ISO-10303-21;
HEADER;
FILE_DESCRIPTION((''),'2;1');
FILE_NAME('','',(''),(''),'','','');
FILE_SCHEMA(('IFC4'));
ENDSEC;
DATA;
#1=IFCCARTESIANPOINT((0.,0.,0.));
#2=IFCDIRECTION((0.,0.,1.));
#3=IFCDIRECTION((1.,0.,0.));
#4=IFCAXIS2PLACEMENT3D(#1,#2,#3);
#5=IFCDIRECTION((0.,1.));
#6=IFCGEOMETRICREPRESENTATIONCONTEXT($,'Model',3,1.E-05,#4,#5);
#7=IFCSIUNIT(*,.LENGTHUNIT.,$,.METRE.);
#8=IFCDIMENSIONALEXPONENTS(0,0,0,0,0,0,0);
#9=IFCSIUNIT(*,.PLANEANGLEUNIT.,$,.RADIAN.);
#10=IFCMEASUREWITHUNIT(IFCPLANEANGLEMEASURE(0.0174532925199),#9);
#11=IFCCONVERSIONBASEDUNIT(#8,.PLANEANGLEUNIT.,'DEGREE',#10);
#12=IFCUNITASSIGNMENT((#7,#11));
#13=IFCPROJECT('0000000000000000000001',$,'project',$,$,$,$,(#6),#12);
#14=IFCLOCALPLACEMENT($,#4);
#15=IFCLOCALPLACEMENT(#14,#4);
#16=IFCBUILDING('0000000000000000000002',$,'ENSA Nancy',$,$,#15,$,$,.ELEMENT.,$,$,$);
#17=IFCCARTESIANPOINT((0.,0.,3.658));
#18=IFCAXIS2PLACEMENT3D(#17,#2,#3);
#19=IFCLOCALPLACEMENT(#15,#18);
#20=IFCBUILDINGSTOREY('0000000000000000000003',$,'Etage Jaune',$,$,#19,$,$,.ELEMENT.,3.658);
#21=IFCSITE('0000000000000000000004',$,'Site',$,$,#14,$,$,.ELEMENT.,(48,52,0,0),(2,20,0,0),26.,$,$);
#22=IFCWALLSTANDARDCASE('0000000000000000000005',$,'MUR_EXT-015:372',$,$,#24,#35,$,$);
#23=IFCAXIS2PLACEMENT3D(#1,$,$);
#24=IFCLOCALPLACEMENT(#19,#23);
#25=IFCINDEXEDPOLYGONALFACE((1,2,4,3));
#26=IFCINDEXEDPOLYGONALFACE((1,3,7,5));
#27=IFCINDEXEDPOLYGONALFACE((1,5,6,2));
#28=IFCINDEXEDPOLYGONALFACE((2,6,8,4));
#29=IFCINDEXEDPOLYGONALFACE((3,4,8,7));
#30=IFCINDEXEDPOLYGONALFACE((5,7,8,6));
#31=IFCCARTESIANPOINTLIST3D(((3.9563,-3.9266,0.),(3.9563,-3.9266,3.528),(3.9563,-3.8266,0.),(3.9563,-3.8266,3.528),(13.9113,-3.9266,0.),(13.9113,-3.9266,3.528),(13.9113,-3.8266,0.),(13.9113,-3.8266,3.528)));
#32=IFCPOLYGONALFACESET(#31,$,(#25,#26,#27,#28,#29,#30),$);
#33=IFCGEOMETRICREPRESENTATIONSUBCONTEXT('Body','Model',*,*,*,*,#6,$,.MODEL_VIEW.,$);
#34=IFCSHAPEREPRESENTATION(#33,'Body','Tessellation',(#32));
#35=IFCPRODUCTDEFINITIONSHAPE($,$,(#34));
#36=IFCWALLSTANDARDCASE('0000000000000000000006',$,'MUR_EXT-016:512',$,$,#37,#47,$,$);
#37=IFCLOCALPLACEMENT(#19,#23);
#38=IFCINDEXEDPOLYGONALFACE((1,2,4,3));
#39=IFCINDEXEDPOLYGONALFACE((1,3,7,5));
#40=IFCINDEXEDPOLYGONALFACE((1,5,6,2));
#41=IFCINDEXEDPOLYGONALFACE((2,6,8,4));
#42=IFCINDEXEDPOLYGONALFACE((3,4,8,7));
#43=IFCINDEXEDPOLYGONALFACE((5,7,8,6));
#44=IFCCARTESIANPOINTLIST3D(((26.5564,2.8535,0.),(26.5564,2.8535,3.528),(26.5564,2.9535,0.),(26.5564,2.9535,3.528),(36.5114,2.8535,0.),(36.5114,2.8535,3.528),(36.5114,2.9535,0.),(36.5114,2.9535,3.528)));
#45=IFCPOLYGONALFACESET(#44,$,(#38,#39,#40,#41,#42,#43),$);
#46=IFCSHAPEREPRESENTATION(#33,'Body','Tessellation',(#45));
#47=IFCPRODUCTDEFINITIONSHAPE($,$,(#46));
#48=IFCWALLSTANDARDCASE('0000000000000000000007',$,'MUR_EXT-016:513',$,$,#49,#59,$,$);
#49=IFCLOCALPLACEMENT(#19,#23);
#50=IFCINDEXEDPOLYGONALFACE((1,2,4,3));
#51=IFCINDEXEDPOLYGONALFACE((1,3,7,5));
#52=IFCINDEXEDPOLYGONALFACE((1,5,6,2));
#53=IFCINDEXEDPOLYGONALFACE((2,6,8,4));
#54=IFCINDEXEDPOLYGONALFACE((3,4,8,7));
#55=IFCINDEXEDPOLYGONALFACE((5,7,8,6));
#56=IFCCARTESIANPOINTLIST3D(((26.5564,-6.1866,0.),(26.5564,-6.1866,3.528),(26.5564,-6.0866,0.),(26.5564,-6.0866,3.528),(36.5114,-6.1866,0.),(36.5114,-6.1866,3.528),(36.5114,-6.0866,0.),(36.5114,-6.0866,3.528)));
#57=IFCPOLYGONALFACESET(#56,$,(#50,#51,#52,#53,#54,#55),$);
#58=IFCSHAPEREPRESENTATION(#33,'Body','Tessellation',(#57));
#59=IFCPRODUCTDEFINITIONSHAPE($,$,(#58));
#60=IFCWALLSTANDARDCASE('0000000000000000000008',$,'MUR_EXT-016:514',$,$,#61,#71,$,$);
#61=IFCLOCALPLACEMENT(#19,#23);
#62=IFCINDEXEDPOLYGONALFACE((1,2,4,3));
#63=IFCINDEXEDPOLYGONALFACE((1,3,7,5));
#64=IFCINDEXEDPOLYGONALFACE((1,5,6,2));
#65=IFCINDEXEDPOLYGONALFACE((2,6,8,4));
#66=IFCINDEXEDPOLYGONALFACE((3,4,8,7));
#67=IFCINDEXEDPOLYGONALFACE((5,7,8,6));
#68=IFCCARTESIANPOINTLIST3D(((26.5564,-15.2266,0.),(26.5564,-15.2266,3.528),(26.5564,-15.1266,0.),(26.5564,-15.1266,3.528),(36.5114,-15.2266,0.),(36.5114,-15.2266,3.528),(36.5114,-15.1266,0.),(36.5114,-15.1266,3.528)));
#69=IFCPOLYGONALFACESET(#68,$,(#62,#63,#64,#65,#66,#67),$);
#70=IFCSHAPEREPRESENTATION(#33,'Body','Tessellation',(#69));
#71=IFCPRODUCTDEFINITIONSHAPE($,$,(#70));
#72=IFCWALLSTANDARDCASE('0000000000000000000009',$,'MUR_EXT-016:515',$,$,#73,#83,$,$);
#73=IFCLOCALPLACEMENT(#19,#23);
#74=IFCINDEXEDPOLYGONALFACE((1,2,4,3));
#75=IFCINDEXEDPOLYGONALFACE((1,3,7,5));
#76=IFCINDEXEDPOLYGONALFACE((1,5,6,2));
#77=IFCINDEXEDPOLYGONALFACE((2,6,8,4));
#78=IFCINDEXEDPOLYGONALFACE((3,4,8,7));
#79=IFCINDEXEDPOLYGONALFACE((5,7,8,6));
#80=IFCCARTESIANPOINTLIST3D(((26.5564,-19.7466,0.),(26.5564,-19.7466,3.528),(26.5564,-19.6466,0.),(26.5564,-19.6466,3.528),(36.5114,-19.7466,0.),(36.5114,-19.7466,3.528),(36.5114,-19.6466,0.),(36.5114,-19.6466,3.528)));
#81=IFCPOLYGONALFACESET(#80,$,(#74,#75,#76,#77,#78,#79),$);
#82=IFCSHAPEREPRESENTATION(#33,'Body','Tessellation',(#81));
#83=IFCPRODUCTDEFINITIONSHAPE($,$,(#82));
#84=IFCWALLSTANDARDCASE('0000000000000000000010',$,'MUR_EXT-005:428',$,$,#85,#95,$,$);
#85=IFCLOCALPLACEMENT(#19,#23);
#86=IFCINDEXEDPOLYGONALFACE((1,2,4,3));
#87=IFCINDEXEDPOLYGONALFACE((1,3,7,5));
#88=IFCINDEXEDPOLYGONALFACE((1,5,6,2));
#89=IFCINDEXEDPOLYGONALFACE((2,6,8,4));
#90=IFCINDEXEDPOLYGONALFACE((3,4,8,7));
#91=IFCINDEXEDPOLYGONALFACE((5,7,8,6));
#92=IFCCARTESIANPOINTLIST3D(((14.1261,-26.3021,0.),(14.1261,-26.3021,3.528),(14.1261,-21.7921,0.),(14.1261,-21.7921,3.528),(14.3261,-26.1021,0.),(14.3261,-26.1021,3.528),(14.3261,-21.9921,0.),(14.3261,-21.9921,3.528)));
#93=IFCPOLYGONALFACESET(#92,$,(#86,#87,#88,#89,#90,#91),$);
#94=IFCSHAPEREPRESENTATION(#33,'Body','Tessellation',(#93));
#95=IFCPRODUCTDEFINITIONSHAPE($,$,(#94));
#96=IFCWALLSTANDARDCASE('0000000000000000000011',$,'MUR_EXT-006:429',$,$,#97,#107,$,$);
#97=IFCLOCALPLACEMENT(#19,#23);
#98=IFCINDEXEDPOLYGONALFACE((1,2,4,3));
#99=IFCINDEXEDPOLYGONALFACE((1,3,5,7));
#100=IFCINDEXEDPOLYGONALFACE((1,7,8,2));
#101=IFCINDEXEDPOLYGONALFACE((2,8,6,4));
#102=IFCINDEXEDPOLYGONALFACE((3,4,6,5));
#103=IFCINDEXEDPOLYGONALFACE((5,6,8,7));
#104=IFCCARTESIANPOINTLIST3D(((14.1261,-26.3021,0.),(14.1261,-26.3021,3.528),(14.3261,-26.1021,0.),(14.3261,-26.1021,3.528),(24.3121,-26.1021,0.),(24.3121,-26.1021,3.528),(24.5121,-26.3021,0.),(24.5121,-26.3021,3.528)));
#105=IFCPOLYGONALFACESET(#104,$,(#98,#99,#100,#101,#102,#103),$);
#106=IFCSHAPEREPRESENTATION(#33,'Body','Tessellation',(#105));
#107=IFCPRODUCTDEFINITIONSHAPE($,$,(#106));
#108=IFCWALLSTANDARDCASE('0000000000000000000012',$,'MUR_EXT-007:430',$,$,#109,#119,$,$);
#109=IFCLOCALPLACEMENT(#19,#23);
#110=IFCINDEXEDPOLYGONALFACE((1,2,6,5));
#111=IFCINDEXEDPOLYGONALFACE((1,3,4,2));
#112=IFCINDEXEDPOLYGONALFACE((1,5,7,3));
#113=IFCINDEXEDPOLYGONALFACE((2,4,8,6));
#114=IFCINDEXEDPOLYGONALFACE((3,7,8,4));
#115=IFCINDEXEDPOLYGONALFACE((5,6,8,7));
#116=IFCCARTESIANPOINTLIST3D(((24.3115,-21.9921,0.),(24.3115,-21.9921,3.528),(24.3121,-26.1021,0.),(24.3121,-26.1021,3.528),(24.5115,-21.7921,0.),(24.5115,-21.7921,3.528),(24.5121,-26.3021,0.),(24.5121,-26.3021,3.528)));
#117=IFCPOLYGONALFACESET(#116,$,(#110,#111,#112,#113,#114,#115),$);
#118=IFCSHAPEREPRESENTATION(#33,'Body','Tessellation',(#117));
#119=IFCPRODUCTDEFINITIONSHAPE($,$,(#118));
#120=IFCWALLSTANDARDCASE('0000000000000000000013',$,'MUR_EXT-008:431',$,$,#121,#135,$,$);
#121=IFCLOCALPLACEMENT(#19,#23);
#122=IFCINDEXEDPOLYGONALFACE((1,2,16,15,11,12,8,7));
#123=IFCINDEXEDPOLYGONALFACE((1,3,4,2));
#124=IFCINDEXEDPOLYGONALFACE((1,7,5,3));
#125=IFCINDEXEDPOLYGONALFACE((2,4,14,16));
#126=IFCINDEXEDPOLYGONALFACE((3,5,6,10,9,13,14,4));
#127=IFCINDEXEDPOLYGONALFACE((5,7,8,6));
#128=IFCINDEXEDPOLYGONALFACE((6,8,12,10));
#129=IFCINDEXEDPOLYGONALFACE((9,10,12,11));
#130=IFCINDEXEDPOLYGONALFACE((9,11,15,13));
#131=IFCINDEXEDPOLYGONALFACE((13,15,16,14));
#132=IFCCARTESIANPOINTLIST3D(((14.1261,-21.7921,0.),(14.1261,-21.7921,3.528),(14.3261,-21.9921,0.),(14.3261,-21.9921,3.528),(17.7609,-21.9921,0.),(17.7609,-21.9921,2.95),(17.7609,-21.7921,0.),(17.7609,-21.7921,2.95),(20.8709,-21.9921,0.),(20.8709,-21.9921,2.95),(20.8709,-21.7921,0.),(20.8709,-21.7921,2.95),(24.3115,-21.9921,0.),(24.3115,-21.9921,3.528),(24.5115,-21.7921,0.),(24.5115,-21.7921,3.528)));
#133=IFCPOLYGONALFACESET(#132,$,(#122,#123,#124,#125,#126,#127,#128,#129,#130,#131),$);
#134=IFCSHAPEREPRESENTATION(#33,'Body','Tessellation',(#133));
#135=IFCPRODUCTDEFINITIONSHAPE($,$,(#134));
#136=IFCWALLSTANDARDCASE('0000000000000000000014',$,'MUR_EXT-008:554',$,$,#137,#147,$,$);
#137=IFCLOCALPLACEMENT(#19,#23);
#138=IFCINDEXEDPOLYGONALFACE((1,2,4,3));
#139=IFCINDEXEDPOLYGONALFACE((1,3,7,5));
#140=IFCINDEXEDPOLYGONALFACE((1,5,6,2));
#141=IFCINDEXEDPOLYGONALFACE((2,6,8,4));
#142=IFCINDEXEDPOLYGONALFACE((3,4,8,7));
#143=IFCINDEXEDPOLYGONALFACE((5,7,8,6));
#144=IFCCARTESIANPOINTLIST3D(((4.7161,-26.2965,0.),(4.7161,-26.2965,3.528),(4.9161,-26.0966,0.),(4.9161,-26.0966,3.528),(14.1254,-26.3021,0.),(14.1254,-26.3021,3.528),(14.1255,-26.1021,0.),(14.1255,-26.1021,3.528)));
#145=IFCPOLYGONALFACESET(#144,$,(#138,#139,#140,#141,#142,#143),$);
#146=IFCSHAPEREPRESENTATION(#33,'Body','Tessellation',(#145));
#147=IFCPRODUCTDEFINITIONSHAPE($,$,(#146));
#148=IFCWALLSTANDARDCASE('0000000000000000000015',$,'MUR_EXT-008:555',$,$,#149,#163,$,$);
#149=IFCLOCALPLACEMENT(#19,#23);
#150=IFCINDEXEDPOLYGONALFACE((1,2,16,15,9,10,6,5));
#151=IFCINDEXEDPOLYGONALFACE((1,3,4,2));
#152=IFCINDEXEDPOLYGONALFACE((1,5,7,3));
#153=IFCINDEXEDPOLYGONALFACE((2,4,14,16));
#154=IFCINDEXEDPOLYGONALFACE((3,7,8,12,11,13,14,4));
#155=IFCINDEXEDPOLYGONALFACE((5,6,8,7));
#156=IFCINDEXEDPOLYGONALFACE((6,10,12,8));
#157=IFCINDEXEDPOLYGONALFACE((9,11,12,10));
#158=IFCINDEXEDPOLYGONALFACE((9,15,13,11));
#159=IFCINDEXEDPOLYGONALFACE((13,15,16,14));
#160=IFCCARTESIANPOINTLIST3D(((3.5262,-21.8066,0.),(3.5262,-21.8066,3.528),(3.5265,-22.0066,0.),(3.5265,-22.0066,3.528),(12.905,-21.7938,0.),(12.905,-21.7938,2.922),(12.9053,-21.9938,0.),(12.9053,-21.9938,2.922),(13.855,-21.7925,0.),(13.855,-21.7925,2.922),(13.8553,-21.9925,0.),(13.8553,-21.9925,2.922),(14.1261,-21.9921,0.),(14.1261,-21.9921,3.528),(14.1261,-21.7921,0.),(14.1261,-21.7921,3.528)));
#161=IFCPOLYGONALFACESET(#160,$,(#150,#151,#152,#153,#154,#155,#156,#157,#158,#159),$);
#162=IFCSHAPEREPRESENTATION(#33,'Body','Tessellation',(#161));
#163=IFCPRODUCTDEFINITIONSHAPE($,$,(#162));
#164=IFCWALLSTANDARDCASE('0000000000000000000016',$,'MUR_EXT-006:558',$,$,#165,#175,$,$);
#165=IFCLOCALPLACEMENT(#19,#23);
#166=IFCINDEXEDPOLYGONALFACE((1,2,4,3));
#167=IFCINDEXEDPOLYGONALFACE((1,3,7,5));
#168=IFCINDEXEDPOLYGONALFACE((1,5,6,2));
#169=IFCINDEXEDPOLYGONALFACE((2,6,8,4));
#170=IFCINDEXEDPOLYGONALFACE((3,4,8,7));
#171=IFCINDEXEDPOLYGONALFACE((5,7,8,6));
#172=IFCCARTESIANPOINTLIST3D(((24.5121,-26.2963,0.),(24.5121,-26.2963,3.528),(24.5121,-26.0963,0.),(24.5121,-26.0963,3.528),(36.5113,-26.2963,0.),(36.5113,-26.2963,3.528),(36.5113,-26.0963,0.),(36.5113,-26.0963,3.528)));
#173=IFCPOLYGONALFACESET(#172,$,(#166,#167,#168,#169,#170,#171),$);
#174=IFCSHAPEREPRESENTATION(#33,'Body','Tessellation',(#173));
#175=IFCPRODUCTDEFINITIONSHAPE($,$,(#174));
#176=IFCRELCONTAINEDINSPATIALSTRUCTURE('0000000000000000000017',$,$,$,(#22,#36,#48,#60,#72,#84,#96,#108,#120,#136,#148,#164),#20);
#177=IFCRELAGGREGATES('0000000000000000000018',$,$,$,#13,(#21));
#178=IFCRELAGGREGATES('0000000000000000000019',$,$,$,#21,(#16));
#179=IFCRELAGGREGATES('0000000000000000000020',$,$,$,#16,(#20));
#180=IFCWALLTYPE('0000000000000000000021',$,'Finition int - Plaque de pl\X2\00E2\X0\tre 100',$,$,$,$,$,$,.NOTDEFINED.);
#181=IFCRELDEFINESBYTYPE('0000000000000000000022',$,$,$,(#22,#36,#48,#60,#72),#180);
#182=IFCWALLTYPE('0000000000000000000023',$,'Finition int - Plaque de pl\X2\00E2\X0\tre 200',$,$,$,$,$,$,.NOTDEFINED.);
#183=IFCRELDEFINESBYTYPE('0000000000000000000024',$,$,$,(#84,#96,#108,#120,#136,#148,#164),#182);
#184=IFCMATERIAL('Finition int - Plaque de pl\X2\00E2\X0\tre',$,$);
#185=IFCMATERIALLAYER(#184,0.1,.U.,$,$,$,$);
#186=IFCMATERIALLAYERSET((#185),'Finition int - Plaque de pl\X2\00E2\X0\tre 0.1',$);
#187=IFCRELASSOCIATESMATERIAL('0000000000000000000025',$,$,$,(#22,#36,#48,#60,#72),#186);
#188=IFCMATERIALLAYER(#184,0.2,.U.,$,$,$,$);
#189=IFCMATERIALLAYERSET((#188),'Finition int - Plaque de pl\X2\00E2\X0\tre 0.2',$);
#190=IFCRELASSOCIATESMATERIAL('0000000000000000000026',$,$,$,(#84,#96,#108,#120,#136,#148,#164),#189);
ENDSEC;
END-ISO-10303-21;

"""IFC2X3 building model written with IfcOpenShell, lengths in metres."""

from ifc_helpers import new_model, entity, si_unit, converted_unit, direction, frame, origin_with_axes, origin_2d_with_axis, place, context, subcontext, project, spatial, polyline, rectangle, outline, extrude, material, layer, layer_set, layer_usage, type_object, element, save


model = new_model("IFC2X3")

# Units and contexts
model_context = context("Model", 3, precision=1e-05, world=origin_with_axes(), true_north=direction((0.0, 1.0)))
body_context = subcontext(model_context, "Body", "Model", "MODEL_VIEW")
ifc_project = project(units=[si_unit("LENGTHUNIT", "METRE"), converted_unit("PLANEANGLEUNIT", "DEGREE", entity("IfcPlaneAngleMeasure", 0.0174532925199), si_unit("PLANEANGLEUNIT", "RADIAN"), dimensions=[0, 0, 0, 0, 0, 0, 0])], contexts=[model_context])

# Site, building, storey
site_placement = place(None, origin_with_axes())
site = spatial("IfcSite", under=ifc_project, at=site_placement, Name="Site", CompositionType="ELEMENT", RefLatitude=(48, 52, 0, 0), RefLongitude=(2, 20, 0, 0), RefElevation=26.0)
building_placement = place(site_placement, origin_with_axes())
building = spatial("IfcBuilding", under=site, at=building_placement, Name="ENSA Nancy", CompositionType="ELEMENT")
storey_placement = place(building_placement, frame((0.0, 0.0, 3.658), z_axis=(0.0, 0.0, 1.0), x_axis=(1.0, 0.0, 0.0)))
storey = spatial("IfcBuildingStorey", under=building, at=storey_placement, Name="Etage Jaune", CompositionType="ELEMENT", Elevation=3.658)

# Walls
ifc_material_1 = material(Name="Finition int - Plaque de plâtre")
ifc_layer_1 = layer(ifc_material_1, 0.1, ventilated="UNKNOWN")
ifc_layer_set_1 = layer_set([ifc_layer_1], Name="Finition int - Plaque de plâtre 0.1")
ifc_layer_usage_1 = layer_usage(ifc_layer_set_1, "AXIS2", "NEGATIVE", 0.1)
wall_type_1 = type_object("IfcWallType", Name="Finition int - Plaque de plâtre 100", PredefinedType="NOTDEFINED")
wall_1_placement = place(storey_placement, frame((3.9563, -3.9266, 0.0), z_axis=(0.0, 0.0, 1.0), x_axis=(1.0, 0.0, 0.0)))
element("IfcWallStandardCase", 1, at=wall_1_placement, inside=storey, type_object=wall_type_1, material=ifc_layer_usage_1, Name="MUR_EXT-015:372", context=body_context, shape_type="SweptSolid", body=[
    extrude(outline(polyline([(0.0, 0.0), (9.955, 0.0), (9.955, 0.1), (0.0, 0.1), (0.0, 0.0)])), origin_with_axes(), (0.0, 0.0, 1.0), 3.528),
])
ifc_layer_usage_2 = layer_usage(ifc_layer_set_1, "AXIS2", "NEGATIVE", 0.1)
wall_2_placement = place(storey_placement, frame((26.5564, 2.8535, 0.0), z_axis=(0.0, 0.0, 1.0), x_axis=(1.0, 0.0, 0.0)))
element("IfcWallStandardCase", 2, at=wall_2_placement, inside=storey, type_object=wall_type_1, material=ifc_layer_usage_2, Name="MUR_EXT-016:512", context=body_context, shape_type="SweptSolid", body=[
    extrude(outline(polyline([(0.0, 0.0), (9.955, 0.0), (9.955, 0.1), (0.0, 0.1), (0.0, 0.0)])), origin_with_axes(), (0.0, 0.0, 1.0), 3.528),
])
ifc_layer_usage_3 = layer_usage(ifc_layer_set_1, "AXIS2", "NEGATIVE", 0.1)
wall_3_placement = place(storey_placement, frame((26.5564, -6.1866, 0.0), z_axis=(0.0, 0.0, 1.0), x_axis=(1.0, 0.0, 0.0)))
element("IfcWallStandardCase", 3, at=wall_3_placement, inside=storey, type_object=wall_type_1, material=ifc_layer_usage_3, Name="MUR_EXT-016:513", context=body_context, shape_type="SweptSolid", body=[
    extrude(outline(polyline([(0.0, 0.0), (9.955, 0.0), (9.955, 0.1), (0.0, 0.1), (0.0, 0.0)])), origin_with_axes(), (0.0, 0.0, 1.0), 3.528),
])
ifc_layer_usage_4 = layer_usage(ifc_layer_set_1, "AXIS2", "NEGATIVE", 0.1)
wall_4_placement = place(storey_placement, frame((26.5564, -15.2266, 0.0), z_axis=(0.0, 0.0, 1.0), x_axis=(1.0, 0.0, 0.0)))
element("IfcWallStandardCase", 4, at=wall_4_placement, inside=storey, type_object=wall_type_1, material=ifc_layer_usage_4, Name="MUR_EXT-016:514", context=body_context, shape_type="SweptSolid", body=[
    extrude(outline(polyline([(0.0, 0.0), (9.955, 0.0), (9.955, 0.1), (0.0, 0.1), (0.0, 0.0)])), origin_with_axes(), (0.0, 0.0, 1.0), 3.528),
])
ifc_layer_usage_5 = layer_usage(ifc_layer_set_1, "AXIS2", "NEGATIVE", 0.1)
wall_5_placement = place(storey_placement, frame((26.5564, -19.7466, 0.0), z_axis=(0.0, 0.0, 1.0), x_axis=(1.0, 0.0, 0.0)))
element("IfcWallStandardCase", 5, at=wall_5_placement, inside=storey, type_object=wall_type_1, material=ifc_layer_usage_5, Name="MUR_EXT-016:515", context=body_context, shape_type="SweptSolid", body=[
    extrude(outline(polyline([(0.0, 0.0), (9.955, 0.0), (9.955, 0.1), (0.0, 0.1), (0.0, 0.0)])), origin_with_axes(), (0.0, 0.0, 1.0), 3.528),
])
ifc_layer_2 = layer(ifc_material_1, 0.2, ventilated="UNKNOWN")
ifc_layer_set_2 = layer_set([ifc_layer_2], Name="Finition int - Plaque de plâtre 0.2")
ifc_layer_usage_6 = layer_usage(ifc_layer_set_2, "AXIS2", "POSITIVE", 0.0)
wall_type_2 = type_object("IfcWallType", Name="Finition int - Plaque de plâtre 200", PredefinedType="NOTDEFINED")
wall_6_placement = place(storey_placement, frame((14.1261, -21.7921, 0.0), z_axis=(0.0, 0.0, 1.0), x_axis=(0.0, -1.0, 0.0)))
element("IfcWallStandardCase", 6, at=wall_6_placement, inside=storey, type_object=wall_type_2, material=ifc_layer_usage_6, Name="MUR_EXT-005:428", context=body_context, shape_type="SweptSolid", body=[
    extrude(outline(polyline([(0.0, 0.0), (4.51, 0.0), (4.31, 0.2), (0.2, 0.2), (0.0, 0.0)])), origin_with_axes(), (0.0, 0.0, 1.0), 3.528),
])
ifc_layer_usage_7 = layer_usage(ifc_layer_set_2, "AXIS2", "POSITIVE", 0.0)
wall_7_placement = place(storey_placement, frame((14.1261, -26.3021, 0.0), z_axis=(0.0, 0.0, 1.0), x_axis=(1.0, 0.000003, 0.0)))
element("IfcWallStandardCase", 7, at=wall_7_placement, inside=storey, type_object=wall_type_2, material=ifc_layer_usage_7, Name="MUR_EXT-006:429", context=body_context, shape_type="SweptSolid", body=[
    extrude(outline(polyline([(0.0, 0.0), (10.386, 0.0), (10.186, 0.2), (0.2, 0.2), (0.0, 0.0)])), origin_with_axes(), (0.0, 0.0, 1.0), 3.528),
])
ifc_layer_usage_8 = layer_usage(ifc_layer_set_2, "AXIS2", "POSITIVE", 0.0)
wall_8_placement = place(storey_placement, frame((24.5121, -26.3021, 0.0), z_axis=(0.0, 0.0, 1.0), x_axis=(-0.00015, 1.0, 0.0)))
element("IfcWallStandardCase", 8, at=wall_8_placement, inside=storey, type_object=wall_type_2, material=ifc_layer_usage_8, Name="MUR_EXT-007:430", context=body_context, shape_type="SweptSolid", body=[
    extrude(outline(polyline([(0.0, 0.0), (4.51, 0.0), (4.31, 0.2), (0.2, 0.2), (0.0, 0.0)])), origin_with_axes(), (0.0, 0.0, 1.0), 3.528),
])

# Wall, opening
ifc_layer_usage_9 = layer_usage(ifc_layer_set_2, "AXIS2", "POSITIVE", 0.0)
wall_9_placement = place(storey_placement, frame((24.5115, -21.7921, 0.0), z_axis=(0.0, 0.0, 1.0), x_axis=(-1.0, -0.000003, 0.0)))
wall_9 = element("IfcWallStandardCase", 9, at=wall_9_placement, inside=storey, type_object=wall_type_2, material=ifc_layer_usage_9, Name="MUR_EXT-008:431", context=body_context, shape_type="SweptSolid", body=[
    extrude(outline(polyline([(0.0, 0.0), (10.3854, 0.0), (10.1854, 0.2), (0.2, 0.2), (0.0, 0.0)])), origin_with_axes(), (0.0, 0.0, 1.0), 3.528),
])
opening_1_placement = place(wall_9_placement, frame((5.1955, 0.0, 0.0), z_axis=(0.0, 0.0, 1.0), x_axis=(1.0, 0.0, 0.0)))
element("IfcOpeningElement", 10, at=opening_1_placement, cuts=wall_9, context=body_context, shape_type="SweptSolid", body=[
    extrude(rectangle(XDim=3.11, YDim=2.95, at=origin_2d_with_axis()), frame((0.0, 0.2, 1.475), z_axis=(0.0, -1.0, 0.0), x_axis=(1.0, 0.0, 0.0)), (0.0, 0.0, 1.0), 0.6),
])

# Wall
ifc_layer_usage_10 = layer_usage(ifc_layer_set_2, "AXIS2", "POSITIVE", 0.0)
wall_10_placement = place(storey_placement, frame((4.7161, -26.2965, 0.0), z_axis=(0.0, 0.0, 1.0), x_axis=(1.0, -0.000596, 0.0)))
element("IfcWallStandardCase", 11, at=wall_10_placement, inside=storey, type_object=wall_type_2, material=ifc_layer_usage_10, Name="MUR_EXT-008:554", context=body_context, shape_type="SweptSolid", body=[
    extrude(outline(polyline([(0.0, 0.0), (9.4092, 0.0), (9.4092, 0.2), (0.1999, 0.2), (0.0, 0.0)])), origin_with_axes(), (0.0, 0.0, 1.0), 3.528),
])

# Wall, opening
ifc_layer_usage_11 = layer_usage(ifc_layer_set_2, "AXIS2", "NEGATIVE", 0.0)
wall_11_placement = place(storey_placement, frame((3.5262, -21.8066, 0.0), z_axis=(0.0, 0.0, 1.0), x_axis=(0.999999, 0.001365, 0.0)))
wall_11 = element("IfcWallStandardCase", 12, at=wall_11_placement, inside=storey, type_object=wall_type_2, material=ifc_layer_usage_11, Name="MUR_EXT-008:555", context=body_context, shape_type="SweptSolid", body=[
    extrude(outline(polyline([(0.0, -0.2), (10.5996, -0.2), (10.5999, 0.0), (0.0, 0.0), (0.0, -0.2)])), origin_with_axes(), (0.0, 0.0, 1.0), 3.528),
])
opening_2_placement = place(wall_11_placement, frame((9.8538, 0.0, 0.0), z_axis=(0.0, 0.0, 1.0), x_axis=(1.0, 0.0, 0.0)))
element("IfcOpeningElement", 13, at=opening_2_placement, cuts=wall_11, context=body_context, shape_type="SweptSolid", body=[
    extrude(rectangle(XDim=0.95, YDim=2.922, at=origin_2d_with_axis()), frame((0.0, -0.2, 1.461), z_axis=(0.0, 1.0, 0.0), x_axis=(1.0, 0.0, 0.0)), (0.0, 0.0, 1.0), 0.6),
])

# Wall
ifc_layer_usage_12 = layer_usage(ifc_layer_set_2, "AXIS2", "NEGATIVE", 0.0)
wall_12_placement = place(storey_placement, frame((36.5113, -26.2963, 0.0), z_axis=(0.0, 0.0, 1.0), x_axis=(-1.0, 0.0, 0.0)))
element("IfcWallStandardCase", 14, at=wall_12_placement, inside=storey, type_object=wall_type_2, material=ifc_layer_usage_12, Name="MUR_EXT-006:558", context=body_context, shape_type="SweptSolid", body=[
    extrude(outline(polyline([(0.0, -0.2), (11.9992, -0.2), (11.9992, 0.0), (0.0, 0.0), (0.0, -0.2)])), origin_with_axes(), (0.0, 0.0, 1.0), 3.528),
])

save(model, "model.ifc")
